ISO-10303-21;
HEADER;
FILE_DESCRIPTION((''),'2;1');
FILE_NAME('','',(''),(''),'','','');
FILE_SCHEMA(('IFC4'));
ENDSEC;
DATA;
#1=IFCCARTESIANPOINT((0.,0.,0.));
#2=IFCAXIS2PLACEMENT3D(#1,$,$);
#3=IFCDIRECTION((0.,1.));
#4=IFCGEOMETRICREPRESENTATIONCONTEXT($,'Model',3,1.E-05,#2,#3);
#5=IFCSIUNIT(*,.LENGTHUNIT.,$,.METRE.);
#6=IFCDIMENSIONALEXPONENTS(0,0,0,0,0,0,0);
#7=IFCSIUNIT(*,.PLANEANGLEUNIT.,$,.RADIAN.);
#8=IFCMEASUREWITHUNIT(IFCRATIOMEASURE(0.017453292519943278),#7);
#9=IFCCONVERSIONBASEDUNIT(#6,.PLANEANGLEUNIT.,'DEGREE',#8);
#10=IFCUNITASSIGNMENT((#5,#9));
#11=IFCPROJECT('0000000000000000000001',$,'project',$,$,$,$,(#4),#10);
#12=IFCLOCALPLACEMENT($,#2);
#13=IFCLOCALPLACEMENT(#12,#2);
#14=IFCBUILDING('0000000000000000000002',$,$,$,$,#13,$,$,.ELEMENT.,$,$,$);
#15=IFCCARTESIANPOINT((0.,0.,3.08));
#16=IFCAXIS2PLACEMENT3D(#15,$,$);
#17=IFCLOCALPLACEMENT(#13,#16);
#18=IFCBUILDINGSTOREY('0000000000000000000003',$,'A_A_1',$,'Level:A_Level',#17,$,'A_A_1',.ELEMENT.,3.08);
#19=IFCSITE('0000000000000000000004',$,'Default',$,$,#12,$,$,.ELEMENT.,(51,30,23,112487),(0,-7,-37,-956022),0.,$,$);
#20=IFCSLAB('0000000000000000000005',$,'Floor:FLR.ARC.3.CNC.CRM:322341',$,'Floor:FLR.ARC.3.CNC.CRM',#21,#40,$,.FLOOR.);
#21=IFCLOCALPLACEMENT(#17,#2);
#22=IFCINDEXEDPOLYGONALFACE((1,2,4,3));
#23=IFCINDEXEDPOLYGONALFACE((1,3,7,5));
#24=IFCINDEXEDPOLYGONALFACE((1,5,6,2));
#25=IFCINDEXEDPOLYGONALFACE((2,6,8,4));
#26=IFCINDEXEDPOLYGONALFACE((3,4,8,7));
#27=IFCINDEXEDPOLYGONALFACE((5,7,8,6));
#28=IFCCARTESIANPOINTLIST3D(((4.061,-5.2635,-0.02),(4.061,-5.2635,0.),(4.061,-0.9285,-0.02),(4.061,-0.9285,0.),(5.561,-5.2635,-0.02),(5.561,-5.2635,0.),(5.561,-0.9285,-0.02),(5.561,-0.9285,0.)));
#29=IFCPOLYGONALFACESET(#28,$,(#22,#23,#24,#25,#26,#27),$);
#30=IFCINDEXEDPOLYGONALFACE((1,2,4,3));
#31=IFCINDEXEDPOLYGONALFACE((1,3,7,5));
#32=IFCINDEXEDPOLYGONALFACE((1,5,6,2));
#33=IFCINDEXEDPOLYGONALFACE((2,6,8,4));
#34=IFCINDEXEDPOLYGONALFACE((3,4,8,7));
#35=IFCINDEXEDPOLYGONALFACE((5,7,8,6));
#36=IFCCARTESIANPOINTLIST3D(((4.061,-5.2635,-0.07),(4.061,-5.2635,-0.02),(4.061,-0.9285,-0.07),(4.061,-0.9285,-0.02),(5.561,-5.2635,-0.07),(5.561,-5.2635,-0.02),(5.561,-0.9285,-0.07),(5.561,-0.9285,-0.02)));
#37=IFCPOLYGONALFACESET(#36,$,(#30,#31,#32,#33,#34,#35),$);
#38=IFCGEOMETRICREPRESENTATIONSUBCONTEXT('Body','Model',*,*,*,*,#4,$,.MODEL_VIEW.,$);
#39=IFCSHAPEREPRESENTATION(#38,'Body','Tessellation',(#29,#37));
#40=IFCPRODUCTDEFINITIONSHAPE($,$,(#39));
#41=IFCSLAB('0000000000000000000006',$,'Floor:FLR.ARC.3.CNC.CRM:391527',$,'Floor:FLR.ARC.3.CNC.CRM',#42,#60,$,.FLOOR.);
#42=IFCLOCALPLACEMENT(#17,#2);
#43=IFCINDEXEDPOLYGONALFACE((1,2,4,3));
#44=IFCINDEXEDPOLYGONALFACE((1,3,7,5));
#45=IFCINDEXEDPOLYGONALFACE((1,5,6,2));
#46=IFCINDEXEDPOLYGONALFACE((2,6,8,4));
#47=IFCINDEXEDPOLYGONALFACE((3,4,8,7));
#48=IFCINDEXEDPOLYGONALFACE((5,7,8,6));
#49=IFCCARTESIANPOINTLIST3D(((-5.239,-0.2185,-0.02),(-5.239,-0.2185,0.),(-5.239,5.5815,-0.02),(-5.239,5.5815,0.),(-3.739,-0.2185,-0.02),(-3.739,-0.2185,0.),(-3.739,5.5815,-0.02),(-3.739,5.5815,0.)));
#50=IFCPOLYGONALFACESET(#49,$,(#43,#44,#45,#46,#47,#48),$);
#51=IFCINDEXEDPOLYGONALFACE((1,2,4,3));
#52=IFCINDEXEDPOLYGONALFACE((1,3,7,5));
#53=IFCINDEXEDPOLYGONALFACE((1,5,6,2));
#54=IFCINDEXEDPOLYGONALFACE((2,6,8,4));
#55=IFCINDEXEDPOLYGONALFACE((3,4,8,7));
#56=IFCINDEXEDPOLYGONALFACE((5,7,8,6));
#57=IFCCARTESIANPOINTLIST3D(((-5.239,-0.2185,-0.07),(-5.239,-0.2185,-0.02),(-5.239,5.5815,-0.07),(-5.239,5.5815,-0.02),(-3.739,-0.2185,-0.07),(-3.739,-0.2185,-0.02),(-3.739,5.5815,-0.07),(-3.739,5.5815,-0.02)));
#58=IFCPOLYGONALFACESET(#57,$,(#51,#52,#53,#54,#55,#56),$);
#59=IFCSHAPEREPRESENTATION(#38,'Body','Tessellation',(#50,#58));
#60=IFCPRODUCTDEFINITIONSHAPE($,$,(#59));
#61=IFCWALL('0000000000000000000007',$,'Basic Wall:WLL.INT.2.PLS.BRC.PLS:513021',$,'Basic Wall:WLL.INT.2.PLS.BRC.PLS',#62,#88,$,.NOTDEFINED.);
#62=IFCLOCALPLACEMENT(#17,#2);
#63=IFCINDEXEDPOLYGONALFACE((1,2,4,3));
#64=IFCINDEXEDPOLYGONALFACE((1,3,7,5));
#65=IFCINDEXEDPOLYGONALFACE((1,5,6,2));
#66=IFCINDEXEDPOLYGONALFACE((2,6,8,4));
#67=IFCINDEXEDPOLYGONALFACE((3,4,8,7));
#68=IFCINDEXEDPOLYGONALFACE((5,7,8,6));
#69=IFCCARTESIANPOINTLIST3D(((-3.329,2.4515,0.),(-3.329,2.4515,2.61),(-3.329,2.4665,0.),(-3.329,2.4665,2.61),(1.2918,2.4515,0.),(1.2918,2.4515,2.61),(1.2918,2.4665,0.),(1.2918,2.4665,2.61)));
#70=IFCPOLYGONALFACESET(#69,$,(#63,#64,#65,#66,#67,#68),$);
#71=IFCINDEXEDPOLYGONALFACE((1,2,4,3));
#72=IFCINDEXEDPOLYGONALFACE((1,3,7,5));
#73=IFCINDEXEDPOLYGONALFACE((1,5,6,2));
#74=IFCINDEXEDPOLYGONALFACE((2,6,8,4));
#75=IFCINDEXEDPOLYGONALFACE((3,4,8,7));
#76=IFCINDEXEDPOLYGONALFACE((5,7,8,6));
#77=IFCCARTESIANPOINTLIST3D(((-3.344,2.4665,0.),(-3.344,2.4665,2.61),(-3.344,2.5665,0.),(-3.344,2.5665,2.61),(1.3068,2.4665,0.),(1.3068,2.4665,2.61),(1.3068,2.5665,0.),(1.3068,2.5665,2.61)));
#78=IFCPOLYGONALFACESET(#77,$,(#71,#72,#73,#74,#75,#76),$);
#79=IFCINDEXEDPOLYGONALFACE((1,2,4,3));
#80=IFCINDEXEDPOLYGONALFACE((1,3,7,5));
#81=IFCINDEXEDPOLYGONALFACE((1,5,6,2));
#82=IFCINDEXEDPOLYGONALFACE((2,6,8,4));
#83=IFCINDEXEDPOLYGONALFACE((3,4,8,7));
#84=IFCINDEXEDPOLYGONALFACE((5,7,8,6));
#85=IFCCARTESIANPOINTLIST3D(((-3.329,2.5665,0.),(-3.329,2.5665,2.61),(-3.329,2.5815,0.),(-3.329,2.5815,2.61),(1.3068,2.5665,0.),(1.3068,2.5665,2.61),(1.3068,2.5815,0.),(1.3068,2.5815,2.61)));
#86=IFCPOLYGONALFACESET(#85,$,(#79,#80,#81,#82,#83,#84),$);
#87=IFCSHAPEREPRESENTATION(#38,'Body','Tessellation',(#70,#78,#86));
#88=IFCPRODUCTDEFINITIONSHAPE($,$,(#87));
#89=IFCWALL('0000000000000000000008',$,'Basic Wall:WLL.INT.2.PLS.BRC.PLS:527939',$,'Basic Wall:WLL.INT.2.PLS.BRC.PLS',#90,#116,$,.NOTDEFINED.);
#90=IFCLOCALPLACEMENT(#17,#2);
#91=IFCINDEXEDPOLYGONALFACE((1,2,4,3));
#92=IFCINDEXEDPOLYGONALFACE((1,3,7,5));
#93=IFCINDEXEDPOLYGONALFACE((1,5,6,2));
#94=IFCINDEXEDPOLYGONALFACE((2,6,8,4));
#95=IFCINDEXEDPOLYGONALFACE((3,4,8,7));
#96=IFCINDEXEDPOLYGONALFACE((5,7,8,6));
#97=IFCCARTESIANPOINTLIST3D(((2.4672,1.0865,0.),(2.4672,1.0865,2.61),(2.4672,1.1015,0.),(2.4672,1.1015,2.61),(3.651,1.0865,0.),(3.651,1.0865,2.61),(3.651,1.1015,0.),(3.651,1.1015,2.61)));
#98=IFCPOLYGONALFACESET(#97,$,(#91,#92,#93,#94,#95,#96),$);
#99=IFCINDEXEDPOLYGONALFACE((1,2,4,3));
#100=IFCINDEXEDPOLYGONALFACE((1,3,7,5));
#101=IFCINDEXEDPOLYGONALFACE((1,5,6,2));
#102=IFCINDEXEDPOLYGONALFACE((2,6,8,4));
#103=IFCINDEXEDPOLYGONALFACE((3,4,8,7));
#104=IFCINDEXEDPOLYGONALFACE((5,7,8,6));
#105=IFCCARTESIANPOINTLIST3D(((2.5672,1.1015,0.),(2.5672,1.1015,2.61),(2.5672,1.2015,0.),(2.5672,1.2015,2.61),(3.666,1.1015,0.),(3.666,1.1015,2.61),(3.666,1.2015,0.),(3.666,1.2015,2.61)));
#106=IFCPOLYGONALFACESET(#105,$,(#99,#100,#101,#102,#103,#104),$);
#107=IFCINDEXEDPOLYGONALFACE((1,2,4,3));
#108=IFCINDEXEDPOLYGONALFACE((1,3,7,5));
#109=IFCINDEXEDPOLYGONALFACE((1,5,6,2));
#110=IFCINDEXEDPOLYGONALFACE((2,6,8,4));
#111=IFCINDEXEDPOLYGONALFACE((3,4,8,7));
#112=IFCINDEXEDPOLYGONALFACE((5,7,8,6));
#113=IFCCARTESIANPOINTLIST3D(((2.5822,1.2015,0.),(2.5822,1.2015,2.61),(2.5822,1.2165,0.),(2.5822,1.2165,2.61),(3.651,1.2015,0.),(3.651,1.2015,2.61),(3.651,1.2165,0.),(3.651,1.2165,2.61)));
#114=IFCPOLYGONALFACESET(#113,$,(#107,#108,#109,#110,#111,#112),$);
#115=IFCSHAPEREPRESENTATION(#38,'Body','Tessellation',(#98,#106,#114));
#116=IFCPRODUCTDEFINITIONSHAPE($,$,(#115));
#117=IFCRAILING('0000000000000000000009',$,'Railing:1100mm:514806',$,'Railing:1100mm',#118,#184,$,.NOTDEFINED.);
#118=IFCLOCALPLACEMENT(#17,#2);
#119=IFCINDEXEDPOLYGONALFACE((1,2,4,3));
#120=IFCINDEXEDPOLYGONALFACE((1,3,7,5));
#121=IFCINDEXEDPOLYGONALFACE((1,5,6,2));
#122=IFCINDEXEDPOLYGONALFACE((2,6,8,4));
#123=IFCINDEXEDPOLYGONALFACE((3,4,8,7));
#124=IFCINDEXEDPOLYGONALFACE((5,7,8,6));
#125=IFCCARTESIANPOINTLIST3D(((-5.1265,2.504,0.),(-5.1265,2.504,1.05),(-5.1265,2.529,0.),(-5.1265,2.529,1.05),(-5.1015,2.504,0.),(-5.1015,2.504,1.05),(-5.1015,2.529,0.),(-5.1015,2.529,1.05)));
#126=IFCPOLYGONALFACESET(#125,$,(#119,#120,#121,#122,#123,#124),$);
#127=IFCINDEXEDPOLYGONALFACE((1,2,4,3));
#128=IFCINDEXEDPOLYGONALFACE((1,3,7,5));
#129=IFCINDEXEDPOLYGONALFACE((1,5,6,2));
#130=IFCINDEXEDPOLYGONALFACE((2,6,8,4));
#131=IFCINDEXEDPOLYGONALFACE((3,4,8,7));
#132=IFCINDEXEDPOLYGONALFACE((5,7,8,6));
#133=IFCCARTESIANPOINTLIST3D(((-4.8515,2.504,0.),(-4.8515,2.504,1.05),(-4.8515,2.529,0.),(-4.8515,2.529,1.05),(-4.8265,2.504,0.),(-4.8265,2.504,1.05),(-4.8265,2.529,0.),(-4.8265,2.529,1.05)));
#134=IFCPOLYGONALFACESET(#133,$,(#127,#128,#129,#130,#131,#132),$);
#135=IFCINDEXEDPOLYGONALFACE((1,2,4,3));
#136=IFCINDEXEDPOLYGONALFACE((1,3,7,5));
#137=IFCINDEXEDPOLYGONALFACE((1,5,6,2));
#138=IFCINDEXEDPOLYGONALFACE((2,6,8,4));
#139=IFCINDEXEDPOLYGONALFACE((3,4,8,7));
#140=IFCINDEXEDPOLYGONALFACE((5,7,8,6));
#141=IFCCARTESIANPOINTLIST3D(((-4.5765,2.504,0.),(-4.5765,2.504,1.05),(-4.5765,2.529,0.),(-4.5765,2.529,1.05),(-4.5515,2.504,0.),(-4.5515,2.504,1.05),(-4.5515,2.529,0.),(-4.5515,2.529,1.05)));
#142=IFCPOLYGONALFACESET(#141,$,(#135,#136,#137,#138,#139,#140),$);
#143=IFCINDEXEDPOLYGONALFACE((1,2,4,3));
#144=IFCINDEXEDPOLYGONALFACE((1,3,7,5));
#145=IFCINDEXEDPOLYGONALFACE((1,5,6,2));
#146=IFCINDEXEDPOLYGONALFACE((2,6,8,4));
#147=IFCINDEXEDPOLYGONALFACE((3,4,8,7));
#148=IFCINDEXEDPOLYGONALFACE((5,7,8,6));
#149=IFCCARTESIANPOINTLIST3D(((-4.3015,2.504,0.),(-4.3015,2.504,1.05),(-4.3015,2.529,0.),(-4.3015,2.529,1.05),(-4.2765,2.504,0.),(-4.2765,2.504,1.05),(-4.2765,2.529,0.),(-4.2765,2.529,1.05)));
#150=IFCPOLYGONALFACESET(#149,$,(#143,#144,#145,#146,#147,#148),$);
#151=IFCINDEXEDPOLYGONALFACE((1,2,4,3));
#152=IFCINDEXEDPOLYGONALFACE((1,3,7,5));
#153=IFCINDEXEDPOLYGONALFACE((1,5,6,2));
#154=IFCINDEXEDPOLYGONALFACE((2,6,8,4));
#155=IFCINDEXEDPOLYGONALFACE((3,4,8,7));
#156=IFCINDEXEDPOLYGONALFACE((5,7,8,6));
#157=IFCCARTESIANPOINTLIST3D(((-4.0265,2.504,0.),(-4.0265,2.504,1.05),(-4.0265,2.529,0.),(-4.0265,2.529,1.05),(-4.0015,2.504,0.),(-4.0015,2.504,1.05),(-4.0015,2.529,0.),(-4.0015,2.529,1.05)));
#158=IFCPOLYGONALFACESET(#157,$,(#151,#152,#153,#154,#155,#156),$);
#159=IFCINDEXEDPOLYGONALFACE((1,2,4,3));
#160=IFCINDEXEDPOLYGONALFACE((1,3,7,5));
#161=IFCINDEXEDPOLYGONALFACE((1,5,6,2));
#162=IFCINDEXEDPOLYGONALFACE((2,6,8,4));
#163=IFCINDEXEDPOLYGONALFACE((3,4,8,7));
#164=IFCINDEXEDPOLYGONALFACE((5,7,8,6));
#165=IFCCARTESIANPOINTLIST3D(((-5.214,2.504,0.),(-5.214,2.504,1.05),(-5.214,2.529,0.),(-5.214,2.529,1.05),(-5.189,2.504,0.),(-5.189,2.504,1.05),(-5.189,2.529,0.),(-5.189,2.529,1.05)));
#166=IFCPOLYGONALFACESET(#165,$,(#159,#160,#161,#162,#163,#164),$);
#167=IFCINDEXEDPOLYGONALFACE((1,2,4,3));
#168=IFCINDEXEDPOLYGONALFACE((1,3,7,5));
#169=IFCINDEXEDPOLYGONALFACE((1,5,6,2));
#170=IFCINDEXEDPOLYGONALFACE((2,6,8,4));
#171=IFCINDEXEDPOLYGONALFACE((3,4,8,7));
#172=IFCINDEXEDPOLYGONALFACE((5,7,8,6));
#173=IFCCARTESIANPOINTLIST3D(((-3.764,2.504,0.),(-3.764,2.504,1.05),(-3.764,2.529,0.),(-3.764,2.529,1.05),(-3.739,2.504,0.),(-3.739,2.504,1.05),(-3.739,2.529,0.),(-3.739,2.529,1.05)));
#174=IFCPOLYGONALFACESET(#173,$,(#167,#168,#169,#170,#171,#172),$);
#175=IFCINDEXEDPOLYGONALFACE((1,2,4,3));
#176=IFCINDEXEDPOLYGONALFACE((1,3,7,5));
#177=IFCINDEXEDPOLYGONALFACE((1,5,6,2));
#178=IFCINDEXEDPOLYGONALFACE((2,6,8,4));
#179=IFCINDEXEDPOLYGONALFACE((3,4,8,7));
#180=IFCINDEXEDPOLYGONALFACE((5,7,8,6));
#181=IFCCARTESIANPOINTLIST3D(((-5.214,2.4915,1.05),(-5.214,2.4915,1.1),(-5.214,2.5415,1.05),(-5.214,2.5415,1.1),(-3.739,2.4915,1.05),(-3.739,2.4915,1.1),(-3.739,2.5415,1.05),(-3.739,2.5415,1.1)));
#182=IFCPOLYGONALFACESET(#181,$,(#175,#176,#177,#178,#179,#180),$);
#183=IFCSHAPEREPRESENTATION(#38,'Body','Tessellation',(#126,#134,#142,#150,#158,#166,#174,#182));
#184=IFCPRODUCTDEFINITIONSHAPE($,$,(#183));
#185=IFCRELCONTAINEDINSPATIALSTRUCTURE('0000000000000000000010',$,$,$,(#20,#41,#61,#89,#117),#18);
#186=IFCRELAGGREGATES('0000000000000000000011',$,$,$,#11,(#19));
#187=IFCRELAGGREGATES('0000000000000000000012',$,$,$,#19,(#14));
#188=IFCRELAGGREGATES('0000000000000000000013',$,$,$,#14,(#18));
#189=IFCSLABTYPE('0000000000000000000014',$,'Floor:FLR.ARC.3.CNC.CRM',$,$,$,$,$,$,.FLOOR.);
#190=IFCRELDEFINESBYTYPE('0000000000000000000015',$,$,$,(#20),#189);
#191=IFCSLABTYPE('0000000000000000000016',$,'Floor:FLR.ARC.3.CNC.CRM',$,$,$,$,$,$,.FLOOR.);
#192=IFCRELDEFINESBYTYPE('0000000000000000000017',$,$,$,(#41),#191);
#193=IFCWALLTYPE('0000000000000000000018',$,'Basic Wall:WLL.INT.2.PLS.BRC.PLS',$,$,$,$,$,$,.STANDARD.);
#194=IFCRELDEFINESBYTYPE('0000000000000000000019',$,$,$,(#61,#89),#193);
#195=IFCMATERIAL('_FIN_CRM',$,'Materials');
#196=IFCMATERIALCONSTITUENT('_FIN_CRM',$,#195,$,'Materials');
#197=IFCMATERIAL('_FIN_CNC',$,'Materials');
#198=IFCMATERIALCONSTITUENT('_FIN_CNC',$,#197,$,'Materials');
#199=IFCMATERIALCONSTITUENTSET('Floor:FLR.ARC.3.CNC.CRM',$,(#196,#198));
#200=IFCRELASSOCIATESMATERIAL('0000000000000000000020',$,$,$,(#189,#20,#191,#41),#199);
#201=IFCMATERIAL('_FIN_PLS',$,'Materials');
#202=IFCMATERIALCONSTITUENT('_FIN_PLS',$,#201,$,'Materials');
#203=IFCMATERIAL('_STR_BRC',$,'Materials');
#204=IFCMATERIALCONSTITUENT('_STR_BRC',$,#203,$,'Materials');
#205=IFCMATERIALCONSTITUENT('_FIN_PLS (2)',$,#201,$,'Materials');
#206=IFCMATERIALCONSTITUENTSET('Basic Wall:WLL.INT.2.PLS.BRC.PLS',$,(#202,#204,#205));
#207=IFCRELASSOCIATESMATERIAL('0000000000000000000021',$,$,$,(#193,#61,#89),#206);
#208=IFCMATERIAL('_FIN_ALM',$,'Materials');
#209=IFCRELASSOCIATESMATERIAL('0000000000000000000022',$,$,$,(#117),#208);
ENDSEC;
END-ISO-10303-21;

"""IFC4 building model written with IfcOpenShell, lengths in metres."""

from ifc_helpers import new_model, entity, si_unit, converted_unit, direction, frame, origin, place, context, subcontext, project, spatial, indexed_curve, outline, extrude, material, constituent, constituent_set, type_object, element, save


model = new_model("IFC4")

# Units and contexts
model_context = context("Model", 3, precision=1e-05, world=origin(), true_north=direction((0.0, 1.0)))
body_context = subcontext(model_context, "Body", "Model", "MODEL_VIEW")
ifc_project = project(units=[si_unit("LENGTHUNIT", "METRE"), converted_unit("PLANEANGLEUNIT", "DEGREE", entity("IfcRatioMeasure", 0.017453292519943278), si_unit("PLANEANGLEUNIT", "RADIAN"), dimensions=[0, 0, 0, 0, 0, 0, 0])], contexts=[model_context])

# Site, building, storey
site_placement = place(None, origin())
site = spatial("IfcSite", under=ifc_project, at=site_placement, Name="Default", CompositionType="ELEMENT", RefLatitude=(51, 30, 23, 112487), RefLongitude=(0, -7, -37, -956022), RefElevation=0.0)
building_placement = place(site_placement, origin())
building = spatial("IfcBuilding", under=site, at=building_placement, CompositionType="ELEMENT")
storey_placement = place(building_placement, frame((0.0, 0.0, 3.08)))
storey = spatial("IfcBuildingStorey", under=building, at=storey_placement, Name="A_A_1", ObjectType="Level:A_Level", LongName="A_A_1", CompositionType="ELEMENT", Elevation=3.08)

# Slabs
ifc_material_1 = material(Name="_FIN_CRM", Category="Materials")
ifc_material_2 = material(Name="_FIN_CNC", Category="Materials")
ifc_constituent_1 = constituent(ifc_material_1, Name="_FIN_CRM", Category="Materials")
ifc_constituent_2 = constituent(ifc_material_2, Name="_FIN_CNC", Category="Materials")
ifc_constituent_set_1 = constituent_set(constituents=[ifc_constituent_1, ifc_constituent_2], Name="Floor:FLR.ARC.3.CNC.CRM")
slab_type_1 = type_object("IfcSlabType", Name="Floor:FLR.ARC.3.CNC.CRM", PredefinedType="FLOOR", material=ifc_constituent_set_1)
slab_1_placement = place(storey_placement, origin())
element("IfcSlab", 1, at=slab_1_placement, inside=storey, type_object=slab_type_1, material=ifc_constituent_set_1, Name="Floor:FLR.ARC.3.CNC.CRM:322341", ObjectType="Floor:FLR.ARC.3.CNC.CRM", PredefinedType="FLOOR", context=body_context, shape_type="SweptSolid", body=[
    extrude(outline(indexed_curve([(-0.75, -2.1675), (0.75, -2.1675), (0.75, 2.1675), (-0.75, 2.1675), (-0.75, -2.1675)], self_intersect=False)), frame((4.811, -3.096, -0.02)), (0.0, 0.0, 1.0), 0.02),
    extrude(outline(indexed_curve([(-0.75, -2.1675), (0.75, -2.1675), (0.75, 2.1675), (-0.75, 2.1675), (-0.75, -2.1675)], self_intersect=False)), frame((4.811, -3.096, -0.07)), (0.0, 0.0, 1.0), 0.05),
])
ifc_material_3 = material(Name="_FIN_PLS", Category="Materials")
slab_type_2 = type_object("IfcSlabType", Name="Floor:FLR.ARC.3.CNC.CRM", PredefinedType="FLOOR", material=ifc_constituent_set_1)
slab_2_placement = place(storey_placement, origin())
element("IfcSlab", 2, at=slab_2_placement, inside=storey, type_object=slab_type_2, material=ifc_constituent_set_1, Name="Floor:FLR.ARC.3.CNC.CRM:391527", ObjectType="Floor:FLR.ARC.3.CNC.CRM", PredefinedType="FLOOR", context=body_context, shape_type="SweptSolid", body=[
    extrude(outline(indexed_curve([(-0.75, -2.9), (0.75, -2.9), (0.75, 2.9), (-0.75, 2.9), (-0.75, -2.9)], self_intersect=False)), frame((-4.489, 2.6815, -0.02), z_axis=(0.0, 0.0, 1.0), x_axis=(-1.0, 0.0, 0.0)), (0.0, 0.0, 1.0), 0.02),
    extrude(outline(indexed_curve([(-0.75, -2.9), (0.75, -2.9), (0.75, 2.9), (-0.75, 2.9), (-0.75, -2.9)], self_intersect=False)), frame((-4.489, 2.6815, -0.07), z_axis=(0.0, 0.0, 1.0), x_axis=(-1.0, 0.0, 0.0)), (0.0, 0.0, 1.0), 0.05),
])

# Shared definitions
ifc_material_4 = material(Name="_STR_BRC", Category="Materials")

# Wall
ifc_constituent_3 = constituent(ifc_material_3, Name="_FIN_PLS", Category="Materials")
ifc_constituent_4 = constituent(ifc_material_4, Name="_STR_BRC", Category="Materials")
ifc_constituent_5 = constituent(ifc_material_3, Name="_FIN_PLS (2)", Category="Materials")
ifc_constituent_set_2 = constituent_set(constituents=[ifc_constituent_3, ifc_constituent_4, ifc_constituent_5], Name="Basic Wall:WLL.INT.2.PLS.BRC.PLS")
wall_type_1 = type_object("IfcWallType", Name="Basic Wall:WLL.INT.2.PLS.BRC.PLS", PredefinedType="STANDARD", material=ifc_constituent_set_2)
wall_1_placement = place(storey_placement, frame((-3.329, 2.5165, 0.0)))
element("IfcWall", 3, at=wall_1_placement, inside=storey, type_object=wall_type_1, material=ifc_constituent_set_2, Name="Basic Wall:WLL.INT.2.PLS.BRC.PLS:513021", ObjectType="Basic Wall:WLL.INT.2.PLS.BRC.PLS", PredefinedType="NOTDEFINED", context=body_context, shape_type="SweptSolid", body=[
    extrude(outline(indexed_curve([(-0.0075, -2.3104), (0.0075, -2.3104), (0.0075, 2.3104), (-0.0075, 2.3104), (-0.0075, -2.3104)], self_intersect=False)), frame((2.3104, -0.0575, 0.0), z_axis=(0.0, 0.0, 1.0), x_axis=(0.0, 1.0, 0.0)), (0.0, 0.0, 1.0), 2.61),
    extrude(outline(indexed_curve([(-2.3254, -0.05), (2.3254, -0.05), (2.3254, 0.05), (-2.3254, 0.05), (-2.3254, -0.05)], self_intersect=False)), frame((2.3104, 0.0, 0.0)), (0.0, 0.0, 1.0), 2.61),
    extrude(outline(indexed_curve([(-0.0075, -2.3179), (0.0075, -2.3179), (0.0075, 2.3179), (-0.0075, 2.3179), (-0.0075, -2.3179)], self_intersect=False)), frame((2.3179, 0.0575, 0.0), z_axis=(0.0, 0.0, 1.0), x_axis=(0.0, -1.0, 0.0)), (0.0, 0.0, 1.0), 2.61),
])

# Wall
wall_2_placement = place(storey_placement, frame((2.5822, 1.1515, 0.0)))
element("IfcWall", 4, at=wall_2_placement, inside=storey, type_object=wall_type_1, material=ifc_constituent_set_2, Name="Basic Wall:WLL.INT.2.PLS.BRC.PLS:527939", ObjectType="Basic Wall:WLL.INT.2.PLS.BRC.PLS", PredefinedType="NOTDEFINED", context=body_context, shape_type="SweptSolid", body=[
    extrude(outline(indexed_curve([(-0.0075, -0.5919), (0.0075, -0.5919), (0.0075, 0.5919), (-0.0075, 0.5919), (-0.0075, -0.5919)], self_intersect=False)), frame((0.4769, -0.0575, 0.0), z_axis=(0.0, 0.0, 1.0), x_axis=(0.0, 1.0, 0.0)), (0.0, 0.0, 1.0), 2.61),
    extrude(outline(indexed_curve([(-0.5494, -0.05), (0.5494, -0.05), (0.5494, 0.05), (-0.5494, 0.05), (-0.5494, -0.05)], self_intersect=False)), frame((0.5344, 0.0, 0.0)), (0.0, 0.0, 1.0), 2.61),
    extrude(outline(indexed_curve([(-0.0075, -0.5344), (0.0075, -0.5344), (0.0075, 0.5344), (-0.0075, 0.5344), (-0.0075, -0.5344)], self_intersect=False)), frame((0.5344, 0.0575, 0.0), z_axis=(0.0, 0.0, 1.0), x_axis=(0.0, -1.0, 0.0)), (0.0, 0.0, 1.0), 2.61),
])

# Railing
ifc_material_5 = material(Name="_FIN_ALM", Category="Materials")
railing_placement = place(storey_placement, origin())
element("IfcRailing", 5, at=railing_placement, inside=storey, material=ifc_material_5, Name="Railing:1100mm:514806", ObjectType="Railing:1100mm", PredefinedType="NOTDEFINED", context=body_context, shape_type="SweptSolid", body=[
    extrude(outline(indexed_curve([(-0.0125, -0.0125), (0.0125, -0.0125), (0.0125, 0.0125), (-0.0125, 0.0125), (-0.0125, -0.0125)], self_intersect=False)), frame((-5.114, 2.5165, 0.0), z_axis=(0.0, 0.0, 1.0), x_axis=(-1.0, 0.0, 0.0)), (0.0, 0.0, 1.0), 1.05),
    extrude(outline(indexed_curve([(-0.0125, -0.0125), (0.0125, -0.0125), (0.0125, 0.0125), (-0.0125, 0.0125), (-0.0125, -0.0125)], self_intersect=False)), frame((-4.839, 2.5165, 0.0), z_axis=(0.0, 0.0, 1.0), x_axis=(-1.0, 0.0, 0.0)), (0.0, 0.0, 1.0), 1.05),
    extrude(outline(indexed_curve([(-0.0125, -0.0125), (0.0125, -0.0125), (0.0125, 0.0125), (-0.0125, 0.0125), (-0.0125, -0.0125)], self_intersect=False)), frame((-4.564, 2.5165, 0.0), z_axis=(0.0, 0.0, 1.0), x_axis=(-1.0, 0.0, 0.0)), (0.0, 0.0, 1.0), 1.05),
    extrude(outline(indexed_curve([(-0.0125, -0.0125), (0.0125, -0.0125), (0.0125, 0.0125), (-0.0125, 0.0125), (-0.0125, -0.0125)], self_intersect=False)), frame((-4.289, 2.5165, 0.0), z_axis=(0.0, 0.0, 1.0), x_axis=(-1.0, 0.0, 0.0)), (0.0, 0.0, 1.0), 1.05),
    extrude(outline(indexed_curve([(-0.0125, -0.0125), (0.0125, -0.0125), (0.0125, 0.0125), (-0.0125, 0.0125), (-0.0125, -0.0125)], self_intersect=False)), frame((-4.014, 2.5165, 0.0), z_axis=(0.0, 0.0, 1.0), x_axis=(-1.0, 0.0, 0.0)), (0.0, 0.0, 1.0), 1.05),
    extrude(outline(indexed_curve([(-0.0125, -0.0125), (0.0125, -0.0125), (0.0125, 0.0125), (-0.0125, 0.0125), (-0.0125, -0.0125)], self_intersect=False)), frame((-5.2015, 2.5165, 0.0), z_axis=(0.0, 0.0, 1.0), x_axis=(-1.0, 0.0, 0.0)), (0.0, 0.0, 1.0), 1.05),
    extrude(outline(indexed_curve([(-0.0125, -0.0125), (0.0125, -0.0125), (0.0125, 0.0125), (-0.0125, 0.0125), (-0.0125, -0.0125)], self_intersect=False)), frame((-3.7515, 2.5165, 0.0), z_axis=(0.0, 0.0, 1.0), x_axis=(-1.0, 0.0, 0.0)), (0.0, 0.0, 1.0), 1.05),
    extrude(outline(indexed_curve([(-0.7375, -0.025), (0.7375, -0.025), (0.7375, 0.025), (-0.7375, 0.025), (-0.7375, -0.025)], self_intersect=False)), frame((-4.4765, 2.5165, 1.05), z_axis=(0.0, 0.0, 1.0), x_axis=(-1.0, 0.0, 0.0)), (0.0, 0.0, 1.0), 0.05),
])

save(model, "model.ifc")
